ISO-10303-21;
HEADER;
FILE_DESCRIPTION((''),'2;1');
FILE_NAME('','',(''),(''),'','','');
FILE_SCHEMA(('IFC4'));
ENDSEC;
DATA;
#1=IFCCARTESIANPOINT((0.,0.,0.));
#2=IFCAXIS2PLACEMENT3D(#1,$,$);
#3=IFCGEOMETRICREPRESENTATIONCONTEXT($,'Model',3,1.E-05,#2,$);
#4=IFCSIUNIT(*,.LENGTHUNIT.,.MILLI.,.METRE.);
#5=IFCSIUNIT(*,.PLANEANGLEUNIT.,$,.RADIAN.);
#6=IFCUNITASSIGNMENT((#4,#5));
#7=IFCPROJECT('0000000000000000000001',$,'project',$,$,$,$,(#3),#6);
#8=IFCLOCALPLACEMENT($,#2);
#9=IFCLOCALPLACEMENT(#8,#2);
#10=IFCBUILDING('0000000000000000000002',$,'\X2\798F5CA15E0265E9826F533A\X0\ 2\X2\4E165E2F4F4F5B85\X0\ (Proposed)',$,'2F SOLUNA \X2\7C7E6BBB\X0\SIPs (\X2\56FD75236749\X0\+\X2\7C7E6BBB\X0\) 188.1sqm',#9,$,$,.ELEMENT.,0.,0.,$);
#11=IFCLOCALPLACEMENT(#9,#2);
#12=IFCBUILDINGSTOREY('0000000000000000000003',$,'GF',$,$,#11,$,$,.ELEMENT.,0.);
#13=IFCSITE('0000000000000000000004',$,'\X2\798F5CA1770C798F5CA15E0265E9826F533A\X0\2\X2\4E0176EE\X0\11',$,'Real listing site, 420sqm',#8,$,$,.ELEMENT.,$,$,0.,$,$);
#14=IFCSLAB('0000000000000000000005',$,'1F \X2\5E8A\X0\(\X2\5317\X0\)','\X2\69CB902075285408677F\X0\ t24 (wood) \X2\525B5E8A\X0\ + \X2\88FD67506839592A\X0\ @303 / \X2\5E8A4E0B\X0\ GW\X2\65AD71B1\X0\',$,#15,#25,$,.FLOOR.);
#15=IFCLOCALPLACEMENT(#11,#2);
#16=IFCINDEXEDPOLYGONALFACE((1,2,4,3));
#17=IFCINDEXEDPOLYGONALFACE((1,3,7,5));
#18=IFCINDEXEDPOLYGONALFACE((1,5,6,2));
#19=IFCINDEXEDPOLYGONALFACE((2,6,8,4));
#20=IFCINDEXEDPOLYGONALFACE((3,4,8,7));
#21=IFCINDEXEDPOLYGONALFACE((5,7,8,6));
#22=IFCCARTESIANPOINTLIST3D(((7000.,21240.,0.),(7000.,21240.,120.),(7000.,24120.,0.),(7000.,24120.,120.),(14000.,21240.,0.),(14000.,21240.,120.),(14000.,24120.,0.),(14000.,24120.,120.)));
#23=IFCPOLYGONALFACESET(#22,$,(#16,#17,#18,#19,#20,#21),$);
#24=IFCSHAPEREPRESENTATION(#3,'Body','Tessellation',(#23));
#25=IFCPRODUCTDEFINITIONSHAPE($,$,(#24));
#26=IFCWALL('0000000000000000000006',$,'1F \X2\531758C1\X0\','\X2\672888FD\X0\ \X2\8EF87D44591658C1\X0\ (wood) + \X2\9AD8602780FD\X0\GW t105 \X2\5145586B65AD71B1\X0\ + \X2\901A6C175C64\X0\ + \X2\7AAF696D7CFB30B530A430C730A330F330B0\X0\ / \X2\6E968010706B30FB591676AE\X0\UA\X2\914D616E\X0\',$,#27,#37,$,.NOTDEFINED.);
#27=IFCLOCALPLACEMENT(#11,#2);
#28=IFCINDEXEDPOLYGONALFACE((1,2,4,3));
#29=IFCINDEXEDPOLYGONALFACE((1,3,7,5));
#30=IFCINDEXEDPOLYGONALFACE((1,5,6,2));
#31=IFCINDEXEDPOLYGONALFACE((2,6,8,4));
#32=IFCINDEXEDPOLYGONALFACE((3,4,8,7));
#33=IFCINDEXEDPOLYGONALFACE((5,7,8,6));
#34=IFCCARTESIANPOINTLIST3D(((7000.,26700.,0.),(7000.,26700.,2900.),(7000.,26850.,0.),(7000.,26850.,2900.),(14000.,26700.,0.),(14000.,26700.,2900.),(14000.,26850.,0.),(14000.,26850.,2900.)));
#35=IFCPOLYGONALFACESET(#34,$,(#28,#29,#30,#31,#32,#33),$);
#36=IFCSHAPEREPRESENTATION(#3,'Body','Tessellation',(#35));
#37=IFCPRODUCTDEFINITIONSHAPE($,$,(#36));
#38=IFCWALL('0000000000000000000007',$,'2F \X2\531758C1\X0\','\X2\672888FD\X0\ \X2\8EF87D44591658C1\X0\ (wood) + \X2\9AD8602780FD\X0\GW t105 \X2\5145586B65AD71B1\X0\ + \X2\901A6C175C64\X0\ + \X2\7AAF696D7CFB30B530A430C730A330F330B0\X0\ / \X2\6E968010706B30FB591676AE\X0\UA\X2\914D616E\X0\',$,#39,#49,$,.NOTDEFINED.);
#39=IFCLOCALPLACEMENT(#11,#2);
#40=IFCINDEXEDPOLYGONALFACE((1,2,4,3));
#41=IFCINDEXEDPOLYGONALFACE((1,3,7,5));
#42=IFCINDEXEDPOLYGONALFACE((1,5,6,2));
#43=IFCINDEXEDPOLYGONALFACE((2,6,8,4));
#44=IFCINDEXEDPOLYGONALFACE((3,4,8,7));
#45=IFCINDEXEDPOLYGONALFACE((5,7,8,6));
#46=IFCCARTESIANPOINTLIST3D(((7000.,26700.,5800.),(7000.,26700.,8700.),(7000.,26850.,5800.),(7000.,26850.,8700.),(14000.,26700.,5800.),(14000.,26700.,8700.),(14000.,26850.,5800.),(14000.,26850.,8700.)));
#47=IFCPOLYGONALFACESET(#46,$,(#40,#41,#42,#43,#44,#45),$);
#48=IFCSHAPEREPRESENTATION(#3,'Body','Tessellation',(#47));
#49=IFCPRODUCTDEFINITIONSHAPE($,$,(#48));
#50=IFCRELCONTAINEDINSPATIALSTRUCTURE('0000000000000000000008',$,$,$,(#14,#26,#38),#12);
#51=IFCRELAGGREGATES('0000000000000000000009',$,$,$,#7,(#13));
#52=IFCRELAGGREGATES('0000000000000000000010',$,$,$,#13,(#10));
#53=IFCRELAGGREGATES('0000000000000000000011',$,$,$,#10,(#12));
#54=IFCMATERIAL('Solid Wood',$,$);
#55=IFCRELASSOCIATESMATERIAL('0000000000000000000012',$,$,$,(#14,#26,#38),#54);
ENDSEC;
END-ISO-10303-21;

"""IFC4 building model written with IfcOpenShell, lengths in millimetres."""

from ifc_helpers import new_model, si_unit, frame, frame_2d, origin, place, context, project, spatial, rectangle, extrude, material, element, save


model = new_model("IFC4")

# Units and contexts
model_context = context("Model", 3, precision=1e-05, world=origin())
ifc_project = project(units=[si_unit("LENGTHUNIT", "METRE", prefix="MILLI"), si_unit("PLANEANGLEUNIT", "RADIAN")], contexts=[model_context])

# Site, building, storey
site_placement = place(None, origin())
site = spatial("IfcSite", under=ifc_project, at=site_placement, Name="福岡県福岡市早良区2丁目11", ObjectType="Real listing site, 420sqm", CompositionType="ELEMENT", RefElevation=0.0)
building_placement = place(site_placement, origin())
building = spatial("IfcBuilding", under=site, at=building_placement, Name="福岡市早良区 2世帯住宅 (Proposed)", ObjectType="2F SOLUNA 籾殻SIPs (国産杉+籾殻) 188.1sqm", CompositionType="ELEMENT", ElevationOfRefHeight=0.0, ElevationOfTerrain=0.0)
storey_placement = place(building_placement, origin())
storey = spatial("IfcBuildingStorey", under=building, at=storey_placement, Name="GF", CompositionType="ELEMENT", Elevation=0.0)

# Slab
ifc_material_1 = material(Name="Solid Wood")
slab_1_placement = place(storey_placement, frame((3500.0, 10620.0, 0.0)))
element("IfcSlab", 1, at=slab_1_placement, inside=storey, material=ifc_material_1, Name="1F 床(北)", Description="構造用合板 t24 (wood) 剛床 + 製材根太 @303 / 床下 GW断熱", PredefinedType="FLOOR", context=model_context, shape_type="SweptSolid", body=[
    extrude(rectangle(XDim=7000.0, YDim=2880.0, at=frame_2d((3500.0, 1440.0))), frame((3500.0, 10620.0, 0.0)), (0.0, 0.0, 1.0), 120.0),
])

# Wall
wall_1_placement = place(storey_placement, frame((3500.0, 13350.0, 0.0)))
element("IfcWall", 2, at=wall_1_placement, inside=storey, material=ifc_material_1, Name="1F 北壁", Description="木製 軸組外壁 (wood) + 高性能GW t105 充填断熱 + 通気層 + 窯業系サイディング / 準耐火・外皮UA配慮", PredefinedType="NOTDEFINED", context=model_context, shape_type="SweptSolid", body=[
    extrude(rectangle(XDim=7000.0, YDim=150.0, at=frame_2d((3500.0, 75.0))), frame((3500.0, 13350.0, 0.0)), (0.0, 0.0, 1.0), 2900.0),
])

# Wall
wall_2_placement = place(storey_placement, frame((3500.0, 13350.0, 2900.0)))
element("IfcWall", 3, at=wall_2_placement, inside=storey, material=ifc_material_1, Name="2F 北壁", Description="木製 軸組外壁 (wood) + 高性能GW t105 充填断熱 + 通気層 + 窯業系サイディング / 準耐火・外皮UA配慮", PredefinedType="NOTDEFINED", context=model_context, shape_type="SweptSolid", body=[
    extrude(rectangle(XDim=7000.0, YDim=150.0, at=frame_2d((3500.0, 75.0))), frame((3500.0, 13350.0, 2900.0)), (0.0, 0.0, 1.0), 2900.0),
])

save(model, "model.ifc")
